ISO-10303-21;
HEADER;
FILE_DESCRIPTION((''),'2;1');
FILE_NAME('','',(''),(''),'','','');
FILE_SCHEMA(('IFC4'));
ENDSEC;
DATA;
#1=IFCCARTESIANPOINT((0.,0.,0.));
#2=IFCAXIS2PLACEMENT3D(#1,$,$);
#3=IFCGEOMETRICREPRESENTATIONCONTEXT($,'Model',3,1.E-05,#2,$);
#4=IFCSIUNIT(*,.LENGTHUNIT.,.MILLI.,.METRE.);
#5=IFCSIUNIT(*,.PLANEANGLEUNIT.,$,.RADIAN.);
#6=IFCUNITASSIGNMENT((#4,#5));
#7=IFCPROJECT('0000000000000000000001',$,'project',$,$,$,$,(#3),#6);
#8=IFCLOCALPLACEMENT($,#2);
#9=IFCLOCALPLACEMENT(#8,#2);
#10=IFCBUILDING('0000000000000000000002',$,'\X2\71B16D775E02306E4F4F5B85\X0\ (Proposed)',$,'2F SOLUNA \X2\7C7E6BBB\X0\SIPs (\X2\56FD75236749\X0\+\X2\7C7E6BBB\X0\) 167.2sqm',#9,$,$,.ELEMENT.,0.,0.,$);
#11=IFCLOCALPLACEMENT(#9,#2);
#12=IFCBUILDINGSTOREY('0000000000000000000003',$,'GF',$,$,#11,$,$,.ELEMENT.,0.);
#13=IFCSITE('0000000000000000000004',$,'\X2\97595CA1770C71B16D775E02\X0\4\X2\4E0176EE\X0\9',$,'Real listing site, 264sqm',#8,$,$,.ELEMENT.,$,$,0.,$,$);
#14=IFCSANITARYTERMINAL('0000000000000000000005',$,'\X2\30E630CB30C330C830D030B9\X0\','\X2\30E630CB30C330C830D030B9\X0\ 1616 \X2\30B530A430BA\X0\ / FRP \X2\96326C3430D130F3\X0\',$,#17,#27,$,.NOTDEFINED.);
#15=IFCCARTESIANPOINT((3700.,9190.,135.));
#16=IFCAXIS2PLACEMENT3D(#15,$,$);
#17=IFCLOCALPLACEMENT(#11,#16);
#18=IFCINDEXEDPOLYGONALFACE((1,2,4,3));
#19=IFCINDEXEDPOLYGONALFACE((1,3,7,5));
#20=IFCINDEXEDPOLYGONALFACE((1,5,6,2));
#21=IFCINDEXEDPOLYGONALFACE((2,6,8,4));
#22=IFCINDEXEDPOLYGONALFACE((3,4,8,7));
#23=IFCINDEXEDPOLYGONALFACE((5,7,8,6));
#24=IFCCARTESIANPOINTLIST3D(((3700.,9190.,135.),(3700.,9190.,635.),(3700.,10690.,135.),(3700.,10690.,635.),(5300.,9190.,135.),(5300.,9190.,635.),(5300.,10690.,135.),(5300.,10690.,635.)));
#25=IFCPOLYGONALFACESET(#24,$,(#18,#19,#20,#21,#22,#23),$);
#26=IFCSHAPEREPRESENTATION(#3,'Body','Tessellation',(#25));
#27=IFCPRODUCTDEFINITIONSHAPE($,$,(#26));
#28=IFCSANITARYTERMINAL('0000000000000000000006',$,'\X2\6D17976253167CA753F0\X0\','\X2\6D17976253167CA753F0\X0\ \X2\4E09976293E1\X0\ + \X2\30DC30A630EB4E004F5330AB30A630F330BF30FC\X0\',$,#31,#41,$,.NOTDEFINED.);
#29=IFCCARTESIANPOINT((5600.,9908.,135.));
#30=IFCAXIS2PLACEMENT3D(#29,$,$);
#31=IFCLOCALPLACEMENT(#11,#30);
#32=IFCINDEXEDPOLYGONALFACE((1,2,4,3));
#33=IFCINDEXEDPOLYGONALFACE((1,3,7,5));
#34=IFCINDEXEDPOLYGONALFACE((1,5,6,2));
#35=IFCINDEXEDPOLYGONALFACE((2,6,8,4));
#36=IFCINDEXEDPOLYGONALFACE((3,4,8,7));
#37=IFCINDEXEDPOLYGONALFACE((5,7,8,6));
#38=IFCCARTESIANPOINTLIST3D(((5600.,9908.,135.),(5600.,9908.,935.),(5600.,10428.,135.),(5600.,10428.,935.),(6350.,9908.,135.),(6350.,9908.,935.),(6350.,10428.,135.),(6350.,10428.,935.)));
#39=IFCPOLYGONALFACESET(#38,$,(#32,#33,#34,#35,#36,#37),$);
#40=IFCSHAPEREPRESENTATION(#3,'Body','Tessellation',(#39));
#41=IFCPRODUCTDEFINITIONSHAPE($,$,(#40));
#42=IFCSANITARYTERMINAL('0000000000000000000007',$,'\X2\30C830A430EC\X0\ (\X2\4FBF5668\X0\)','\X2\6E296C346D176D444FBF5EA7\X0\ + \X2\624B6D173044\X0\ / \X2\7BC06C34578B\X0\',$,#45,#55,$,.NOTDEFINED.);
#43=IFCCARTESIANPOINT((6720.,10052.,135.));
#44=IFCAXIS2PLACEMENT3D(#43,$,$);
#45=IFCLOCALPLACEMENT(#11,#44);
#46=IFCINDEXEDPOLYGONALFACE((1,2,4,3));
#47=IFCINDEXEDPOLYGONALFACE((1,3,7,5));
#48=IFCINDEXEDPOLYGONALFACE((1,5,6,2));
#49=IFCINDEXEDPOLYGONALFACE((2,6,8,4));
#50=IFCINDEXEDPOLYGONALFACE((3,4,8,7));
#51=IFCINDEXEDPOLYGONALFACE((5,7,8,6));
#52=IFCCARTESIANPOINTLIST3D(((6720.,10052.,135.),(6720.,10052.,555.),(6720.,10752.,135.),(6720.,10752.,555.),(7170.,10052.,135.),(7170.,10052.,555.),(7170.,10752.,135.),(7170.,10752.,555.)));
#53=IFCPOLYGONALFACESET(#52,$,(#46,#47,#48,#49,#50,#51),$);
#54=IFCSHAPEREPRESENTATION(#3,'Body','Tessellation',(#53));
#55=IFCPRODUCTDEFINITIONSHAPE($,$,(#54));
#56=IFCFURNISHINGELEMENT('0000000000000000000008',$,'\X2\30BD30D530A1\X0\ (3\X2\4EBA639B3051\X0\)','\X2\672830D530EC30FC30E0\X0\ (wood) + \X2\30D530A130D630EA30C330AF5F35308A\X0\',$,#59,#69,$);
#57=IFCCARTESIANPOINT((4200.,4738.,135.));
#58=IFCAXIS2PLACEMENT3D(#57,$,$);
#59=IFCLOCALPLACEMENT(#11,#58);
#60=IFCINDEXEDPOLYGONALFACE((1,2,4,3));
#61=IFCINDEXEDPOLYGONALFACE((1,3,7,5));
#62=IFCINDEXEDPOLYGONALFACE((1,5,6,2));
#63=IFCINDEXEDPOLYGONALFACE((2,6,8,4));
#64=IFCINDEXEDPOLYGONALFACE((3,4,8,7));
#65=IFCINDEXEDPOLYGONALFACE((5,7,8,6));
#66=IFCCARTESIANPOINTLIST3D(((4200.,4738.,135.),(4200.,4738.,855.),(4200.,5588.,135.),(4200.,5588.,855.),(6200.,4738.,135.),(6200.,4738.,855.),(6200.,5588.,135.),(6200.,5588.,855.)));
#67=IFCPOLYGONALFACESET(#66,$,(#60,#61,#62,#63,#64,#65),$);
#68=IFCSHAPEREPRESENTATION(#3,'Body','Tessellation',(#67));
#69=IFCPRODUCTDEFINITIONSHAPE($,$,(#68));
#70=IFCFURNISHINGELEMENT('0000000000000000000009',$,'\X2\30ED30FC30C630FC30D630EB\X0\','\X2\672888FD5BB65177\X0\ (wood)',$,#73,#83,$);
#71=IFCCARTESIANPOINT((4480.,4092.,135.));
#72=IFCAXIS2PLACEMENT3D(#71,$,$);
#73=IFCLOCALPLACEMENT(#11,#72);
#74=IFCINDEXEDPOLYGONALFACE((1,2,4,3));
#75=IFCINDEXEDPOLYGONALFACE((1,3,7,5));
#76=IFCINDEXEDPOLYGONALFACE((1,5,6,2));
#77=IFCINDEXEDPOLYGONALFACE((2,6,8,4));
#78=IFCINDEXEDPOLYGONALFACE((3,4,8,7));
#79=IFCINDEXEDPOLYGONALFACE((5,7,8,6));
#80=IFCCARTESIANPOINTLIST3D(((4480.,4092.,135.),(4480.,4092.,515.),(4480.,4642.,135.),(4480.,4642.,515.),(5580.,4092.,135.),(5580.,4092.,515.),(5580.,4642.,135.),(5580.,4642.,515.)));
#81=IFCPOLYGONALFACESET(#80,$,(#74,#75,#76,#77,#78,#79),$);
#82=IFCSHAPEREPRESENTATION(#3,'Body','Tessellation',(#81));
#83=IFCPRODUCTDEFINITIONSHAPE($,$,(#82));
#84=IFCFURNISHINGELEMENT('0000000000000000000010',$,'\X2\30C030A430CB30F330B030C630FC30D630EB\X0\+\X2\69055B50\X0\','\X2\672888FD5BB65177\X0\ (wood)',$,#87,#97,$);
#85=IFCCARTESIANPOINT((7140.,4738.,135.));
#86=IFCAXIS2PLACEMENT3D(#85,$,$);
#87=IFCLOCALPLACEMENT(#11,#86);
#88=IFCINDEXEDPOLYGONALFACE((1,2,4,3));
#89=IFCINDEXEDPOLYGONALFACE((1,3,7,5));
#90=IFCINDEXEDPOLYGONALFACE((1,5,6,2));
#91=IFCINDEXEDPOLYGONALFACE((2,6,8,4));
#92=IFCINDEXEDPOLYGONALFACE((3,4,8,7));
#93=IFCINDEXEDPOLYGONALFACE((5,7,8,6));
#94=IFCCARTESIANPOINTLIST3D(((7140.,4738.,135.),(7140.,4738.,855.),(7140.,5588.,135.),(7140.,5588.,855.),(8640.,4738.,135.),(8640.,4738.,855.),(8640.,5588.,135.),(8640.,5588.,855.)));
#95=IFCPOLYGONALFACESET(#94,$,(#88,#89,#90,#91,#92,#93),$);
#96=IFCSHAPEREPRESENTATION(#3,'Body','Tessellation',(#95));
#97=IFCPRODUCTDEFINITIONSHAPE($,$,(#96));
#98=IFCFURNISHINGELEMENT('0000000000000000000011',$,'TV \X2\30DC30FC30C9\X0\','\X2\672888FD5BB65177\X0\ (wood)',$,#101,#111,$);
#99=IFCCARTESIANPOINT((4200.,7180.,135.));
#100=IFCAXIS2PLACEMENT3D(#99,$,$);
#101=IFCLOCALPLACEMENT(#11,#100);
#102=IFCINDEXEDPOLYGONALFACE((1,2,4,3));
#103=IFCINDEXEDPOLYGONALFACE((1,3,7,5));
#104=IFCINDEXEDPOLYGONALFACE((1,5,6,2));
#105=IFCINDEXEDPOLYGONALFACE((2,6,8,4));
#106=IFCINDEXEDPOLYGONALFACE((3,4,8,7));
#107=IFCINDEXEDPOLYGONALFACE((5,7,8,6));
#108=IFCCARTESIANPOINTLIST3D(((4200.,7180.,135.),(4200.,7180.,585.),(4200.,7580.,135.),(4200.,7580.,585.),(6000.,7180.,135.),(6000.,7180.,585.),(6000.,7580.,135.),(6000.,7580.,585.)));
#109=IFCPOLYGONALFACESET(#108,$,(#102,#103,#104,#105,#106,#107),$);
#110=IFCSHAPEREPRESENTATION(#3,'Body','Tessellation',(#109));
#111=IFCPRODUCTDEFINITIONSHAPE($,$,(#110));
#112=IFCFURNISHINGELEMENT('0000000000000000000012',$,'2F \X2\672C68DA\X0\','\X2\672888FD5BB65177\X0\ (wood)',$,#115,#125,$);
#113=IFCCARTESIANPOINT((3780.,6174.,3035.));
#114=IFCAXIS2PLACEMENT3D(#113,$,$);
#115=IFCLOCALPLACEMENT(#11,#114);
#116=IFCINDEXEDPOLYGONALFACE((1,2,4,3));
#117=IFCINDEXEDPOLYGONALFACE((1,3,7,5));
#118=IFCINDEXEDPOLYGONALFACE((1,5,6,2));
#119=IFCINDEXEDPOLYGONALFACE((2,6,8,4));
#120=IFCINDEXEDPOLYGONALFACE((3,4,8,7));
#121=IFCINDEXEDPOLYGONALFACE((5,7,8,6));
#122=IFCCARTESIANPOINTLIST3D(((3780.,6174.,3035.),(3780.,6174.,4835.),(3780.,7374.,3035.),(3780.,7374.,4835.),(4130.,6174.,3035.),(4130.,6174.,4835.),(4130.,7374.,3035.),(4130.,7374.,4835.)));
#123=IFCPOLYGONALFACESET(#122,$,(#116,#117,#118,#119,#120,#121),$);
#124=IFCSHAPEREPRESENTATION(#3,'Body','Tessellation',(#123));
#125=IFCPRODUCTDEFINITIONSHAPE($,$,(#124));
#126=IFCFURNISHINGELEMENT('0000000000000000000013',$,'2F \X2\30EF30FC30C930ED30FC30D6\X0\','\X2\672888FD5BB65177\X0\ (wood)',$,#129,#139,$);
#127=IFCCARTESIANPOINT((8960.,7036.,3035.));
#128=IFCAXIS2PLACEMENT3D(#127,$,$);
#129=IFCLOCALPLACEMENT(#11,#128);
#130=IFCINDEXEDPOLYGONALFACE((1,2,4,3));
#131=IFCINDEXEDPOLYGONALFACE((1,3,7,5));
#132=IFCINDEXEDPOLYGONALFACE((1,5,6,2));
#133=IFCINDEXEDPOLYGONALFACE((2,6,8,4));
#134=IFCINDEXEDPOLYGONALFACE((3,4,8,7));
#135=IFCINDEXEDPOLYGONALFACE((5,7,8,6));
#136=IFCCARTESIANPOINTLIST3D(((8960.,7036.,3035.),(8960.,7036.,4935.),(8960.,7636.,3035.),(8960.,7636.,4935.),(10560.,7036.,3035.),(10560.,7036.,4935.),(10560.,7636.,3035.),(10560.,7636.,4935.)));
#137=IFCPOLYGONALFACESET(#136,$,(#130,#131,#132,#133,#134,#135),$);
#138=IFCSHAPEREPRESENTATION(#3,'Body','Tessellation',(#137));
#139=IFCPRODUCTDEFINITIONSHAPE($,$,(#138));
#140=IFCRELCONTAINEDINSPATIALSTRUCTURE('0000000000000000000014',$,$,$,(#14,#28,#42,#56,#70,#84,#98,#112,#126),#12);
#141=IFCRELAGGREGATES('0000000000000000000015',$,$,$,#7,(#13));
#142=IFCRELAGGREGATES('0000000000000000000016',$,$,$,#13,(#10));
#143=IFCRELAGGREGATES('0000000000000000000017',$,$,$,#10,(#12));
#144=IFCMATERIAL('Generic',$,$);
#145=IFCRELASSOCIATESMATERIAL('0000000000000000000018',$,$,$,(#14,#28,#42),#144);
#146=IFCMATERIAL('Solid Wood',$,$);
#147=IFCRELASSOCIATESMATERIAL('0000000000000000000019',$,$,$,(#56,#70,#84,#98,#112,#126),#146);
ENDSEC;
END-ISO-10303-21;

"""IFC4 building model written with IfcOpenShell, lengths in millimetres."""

from ifc_helpers import new_model, si_unit, frame, frame_2d, origin, place, context, project, spatial, rectangle, extrude, material, element, save


model = new_model("IFC4")

# Units and contexts
model_context = context("Model", 3, precision=1e-05, world=origin())
ifc_project = project(units=[si_unit("LENGTHUNIT", "METRE", prefix="MILLI"), si_unit("PLANEANGLEUNIT", "RADIAN")], contexts=[model_context])

# Site, building, storey
site_placement = place(None, origin())
site = spatial("IfcSite", under=ifc_project, at=site_placement, Name="静岡県熱海市4丁目9", ObjectType="Real listing site, 264sqm", CompositionType="ELEMENT", RefElevation=0.0)
building_placement = place(site_placement, origin())
building = spatial("IfcBuilding", under=site, at=building_placement, Name="熱海市の住宅 (Proposed)", ObjectType="2F SOLUNA 籾殻SIPs (国産杉+籾殻) 167.2sqm", CompositionType="ELEMENT", ElevationOfRefHeight=0.0, ElevationOfTerrain=0.0)
storey_placement = place(building_placement, origin())
storey = spatial("IfcBuildingStorey", under=building, at=storey_placement, Name="GF", CompositionType="ELEMENT", Elevation=0.0)

# Shared definitions
ifc_material_1 = material(Name="Generic")

# Shared definitions
ifc_material_2 = material(Name="Solid Wood")

# Sanitary terminals
sanitary_terminal_1_placement = place(storey_placement, frame((3700.0, 9190.0, 135.0)))
element("IfcSanitaryTerminal", 1, at=sanitary_terminal_1_placement, inside=storey, material=ifc_material_1, Name="ユニットバス", Description="ユニットバス 1616 サイズ / FRP 防水パン", PredefinedType="NOTDEFINED", context=model_context, shape_type="SweptSolid", body=[
    extrude(rectangle(XDim=1600.0, YDim=1500.0, at=frame_2d((800.0, 750.0))), frame((3700.0, 9190.0, 135.0)), (0.0, 0.0, 1.0), 500.0),
])
sanitary_terminal_2_placement = place(storey_placement, frame((5600.0, 9908.0, 135.0)))
element("IfcSanitaryTerminal", 2, at=sanitary_terminal_2_placement, inside=storey, material=ifc_material_1, Name="洗面化粧台", Description="洗面化粧台 三面鏡 + ボウル一体カウンター", PredefinedType="NOTDEFINED", context=model_context, shape_type="SweptSolid", body=[
    extrude(rectangle(XDim=750.0, YDim=520.0, at=frame_2d((375.0, 260.0))), frame((5600.0, 9908.0, 135.0)), (0.0, 0.0, 1.0), 800.0),
])
sanitary_terminal_3_placement = place(storey_placement, frame((6720.0, 10052.0, 135.0)))
element("IfcSanitaryTerminal", 3, at=sanitary_terminal_3_placement, inside=storey, material=ifc_material_1, Name="トイレ (便器)", Description="温水洗浄便座 + 手洗い / 節水型", PredefinedType="NOTDEFINED", context=model_context, shape_type="SweptSolid", body=[
    extrude(rectangle(XDim=450.0, YDim=700.0, at=frame_2d((225.0, 350.0))), frame((6720.0, 10052.0, 135.0)), (0.0, 0.0, 1.0), 420.0),
])

# Furnishing elements
furnishing_1_placement = place(storey_placement, frame((4200.0, 4738.0, 135.0)))
element("IfcFurnishingElement", 4, at=furnishing_1_placement, inside=storey, material=ifc_material_2, Name="ソファ (3人掛け)", Description="木フレーム (wood) + ファブリック張り", context=model_context, shape_type="SweptSolid", body=[
    extrude(rectangle(XDim=2000.0, YDim=850.0, at=frame_2d((1000.0, 425.0))), frame((4200.0, 4738.0, 135.0)), (0.0, 0.0, 1.0), 720.0),
])
furnishing_2_placement = place(storey_placement, frame((4480.0, 4092.0, 135.0)))
element("IfcFurnishingElement", 5, at=furnishing_2_placement, inside=storey, material=ifc_material_2, Name="ローテーブル", Description="木製家具 (wood)", context=model_context, shape_type="SweptSolid", body=[
    extrude(rectangle(XDim=1100.0, YDim=550.0, at=frame_2d((550.0, 275.0))), frame((4480.0, 4092.0, 135.0)), (0.0, 0.0, 1.0), 380.0),
])
furnishing_3_placement = place(storey_placement, frame((7140.0, 4738.0, 135.0)))
element("IfcFurnishingElement", 6, at=furnishing_3_placement, inside=storey, material=ifc_material_2, Name="ダイニングテーブル+椅子", Description="木製家具 (wood)", context=model_context, shape_type="SweptSolid", body=[
    extrude(rectangle(XDim=1500.0, YDim=850.0, at=frame_2d((750.0, 425.0))), frame((7140.0, 4738.0, 135.0)), (0.0, 0.0, 1.0), 720.0),
])
furnishing_4_placement = place(storey_placement, frame((4200.0, 7180.0, 135.0)))
element("IfcFurnishingElement", 7, at=furnishing_4_placement, inside=storey, material=ifc_material_2, Name="TV ボード", Description="木製家具 (wood)", context=model_context, shape_type="SweptSolid", body=[
    extrude(rectangle(XDim=1800.0, YDim=400.0, at=frame_2d((900.0, 200.0))), frame((4200.0, 7180.0, 135.0)), (0.0, 0.0, 1.0), 450.0),
])
furnishing_5_placement = place(storey_placement, frame((3780.0, 6174.0, 3035.0)))
element("IfcFurnishingElement", 8, at=furnishing_5_placement, inside=storey, material=ifc_material_2, Name="2F 本棚", Description="木製家具 (wood)", context=model_context, shape_type="SweptSolid", body=[
    extrude(rectangle(XDim=350.0, YDim=1200.0, at=frame_2d((175.0, 600.0))), frame((3780.0, 6174.0, 3035.0)), (0.0, 0.0, 1.0), 1800.0),
])
furnishing_6_placement = place(storey_placement, frame((8960.0, 7036.0, 3035.0)))
element("IfcFurnishingElement", 9, at=furnishing_6_placement, inside=storey, material=ifc_material_2, Name="2F ワードローブ", Description="木製家具 (wood)", context=model_context, shape_type="SweptSolid", body=[
    extrude(rectangle(XDim=1600.0, YDim=600.0, at=frame_2d((800.0, 300.0))), frame((8960.0, 7036.0, 3035.0)), (0.0, 0.0, 1.0), 1900.0),
])

save(model, "model.ifc")
